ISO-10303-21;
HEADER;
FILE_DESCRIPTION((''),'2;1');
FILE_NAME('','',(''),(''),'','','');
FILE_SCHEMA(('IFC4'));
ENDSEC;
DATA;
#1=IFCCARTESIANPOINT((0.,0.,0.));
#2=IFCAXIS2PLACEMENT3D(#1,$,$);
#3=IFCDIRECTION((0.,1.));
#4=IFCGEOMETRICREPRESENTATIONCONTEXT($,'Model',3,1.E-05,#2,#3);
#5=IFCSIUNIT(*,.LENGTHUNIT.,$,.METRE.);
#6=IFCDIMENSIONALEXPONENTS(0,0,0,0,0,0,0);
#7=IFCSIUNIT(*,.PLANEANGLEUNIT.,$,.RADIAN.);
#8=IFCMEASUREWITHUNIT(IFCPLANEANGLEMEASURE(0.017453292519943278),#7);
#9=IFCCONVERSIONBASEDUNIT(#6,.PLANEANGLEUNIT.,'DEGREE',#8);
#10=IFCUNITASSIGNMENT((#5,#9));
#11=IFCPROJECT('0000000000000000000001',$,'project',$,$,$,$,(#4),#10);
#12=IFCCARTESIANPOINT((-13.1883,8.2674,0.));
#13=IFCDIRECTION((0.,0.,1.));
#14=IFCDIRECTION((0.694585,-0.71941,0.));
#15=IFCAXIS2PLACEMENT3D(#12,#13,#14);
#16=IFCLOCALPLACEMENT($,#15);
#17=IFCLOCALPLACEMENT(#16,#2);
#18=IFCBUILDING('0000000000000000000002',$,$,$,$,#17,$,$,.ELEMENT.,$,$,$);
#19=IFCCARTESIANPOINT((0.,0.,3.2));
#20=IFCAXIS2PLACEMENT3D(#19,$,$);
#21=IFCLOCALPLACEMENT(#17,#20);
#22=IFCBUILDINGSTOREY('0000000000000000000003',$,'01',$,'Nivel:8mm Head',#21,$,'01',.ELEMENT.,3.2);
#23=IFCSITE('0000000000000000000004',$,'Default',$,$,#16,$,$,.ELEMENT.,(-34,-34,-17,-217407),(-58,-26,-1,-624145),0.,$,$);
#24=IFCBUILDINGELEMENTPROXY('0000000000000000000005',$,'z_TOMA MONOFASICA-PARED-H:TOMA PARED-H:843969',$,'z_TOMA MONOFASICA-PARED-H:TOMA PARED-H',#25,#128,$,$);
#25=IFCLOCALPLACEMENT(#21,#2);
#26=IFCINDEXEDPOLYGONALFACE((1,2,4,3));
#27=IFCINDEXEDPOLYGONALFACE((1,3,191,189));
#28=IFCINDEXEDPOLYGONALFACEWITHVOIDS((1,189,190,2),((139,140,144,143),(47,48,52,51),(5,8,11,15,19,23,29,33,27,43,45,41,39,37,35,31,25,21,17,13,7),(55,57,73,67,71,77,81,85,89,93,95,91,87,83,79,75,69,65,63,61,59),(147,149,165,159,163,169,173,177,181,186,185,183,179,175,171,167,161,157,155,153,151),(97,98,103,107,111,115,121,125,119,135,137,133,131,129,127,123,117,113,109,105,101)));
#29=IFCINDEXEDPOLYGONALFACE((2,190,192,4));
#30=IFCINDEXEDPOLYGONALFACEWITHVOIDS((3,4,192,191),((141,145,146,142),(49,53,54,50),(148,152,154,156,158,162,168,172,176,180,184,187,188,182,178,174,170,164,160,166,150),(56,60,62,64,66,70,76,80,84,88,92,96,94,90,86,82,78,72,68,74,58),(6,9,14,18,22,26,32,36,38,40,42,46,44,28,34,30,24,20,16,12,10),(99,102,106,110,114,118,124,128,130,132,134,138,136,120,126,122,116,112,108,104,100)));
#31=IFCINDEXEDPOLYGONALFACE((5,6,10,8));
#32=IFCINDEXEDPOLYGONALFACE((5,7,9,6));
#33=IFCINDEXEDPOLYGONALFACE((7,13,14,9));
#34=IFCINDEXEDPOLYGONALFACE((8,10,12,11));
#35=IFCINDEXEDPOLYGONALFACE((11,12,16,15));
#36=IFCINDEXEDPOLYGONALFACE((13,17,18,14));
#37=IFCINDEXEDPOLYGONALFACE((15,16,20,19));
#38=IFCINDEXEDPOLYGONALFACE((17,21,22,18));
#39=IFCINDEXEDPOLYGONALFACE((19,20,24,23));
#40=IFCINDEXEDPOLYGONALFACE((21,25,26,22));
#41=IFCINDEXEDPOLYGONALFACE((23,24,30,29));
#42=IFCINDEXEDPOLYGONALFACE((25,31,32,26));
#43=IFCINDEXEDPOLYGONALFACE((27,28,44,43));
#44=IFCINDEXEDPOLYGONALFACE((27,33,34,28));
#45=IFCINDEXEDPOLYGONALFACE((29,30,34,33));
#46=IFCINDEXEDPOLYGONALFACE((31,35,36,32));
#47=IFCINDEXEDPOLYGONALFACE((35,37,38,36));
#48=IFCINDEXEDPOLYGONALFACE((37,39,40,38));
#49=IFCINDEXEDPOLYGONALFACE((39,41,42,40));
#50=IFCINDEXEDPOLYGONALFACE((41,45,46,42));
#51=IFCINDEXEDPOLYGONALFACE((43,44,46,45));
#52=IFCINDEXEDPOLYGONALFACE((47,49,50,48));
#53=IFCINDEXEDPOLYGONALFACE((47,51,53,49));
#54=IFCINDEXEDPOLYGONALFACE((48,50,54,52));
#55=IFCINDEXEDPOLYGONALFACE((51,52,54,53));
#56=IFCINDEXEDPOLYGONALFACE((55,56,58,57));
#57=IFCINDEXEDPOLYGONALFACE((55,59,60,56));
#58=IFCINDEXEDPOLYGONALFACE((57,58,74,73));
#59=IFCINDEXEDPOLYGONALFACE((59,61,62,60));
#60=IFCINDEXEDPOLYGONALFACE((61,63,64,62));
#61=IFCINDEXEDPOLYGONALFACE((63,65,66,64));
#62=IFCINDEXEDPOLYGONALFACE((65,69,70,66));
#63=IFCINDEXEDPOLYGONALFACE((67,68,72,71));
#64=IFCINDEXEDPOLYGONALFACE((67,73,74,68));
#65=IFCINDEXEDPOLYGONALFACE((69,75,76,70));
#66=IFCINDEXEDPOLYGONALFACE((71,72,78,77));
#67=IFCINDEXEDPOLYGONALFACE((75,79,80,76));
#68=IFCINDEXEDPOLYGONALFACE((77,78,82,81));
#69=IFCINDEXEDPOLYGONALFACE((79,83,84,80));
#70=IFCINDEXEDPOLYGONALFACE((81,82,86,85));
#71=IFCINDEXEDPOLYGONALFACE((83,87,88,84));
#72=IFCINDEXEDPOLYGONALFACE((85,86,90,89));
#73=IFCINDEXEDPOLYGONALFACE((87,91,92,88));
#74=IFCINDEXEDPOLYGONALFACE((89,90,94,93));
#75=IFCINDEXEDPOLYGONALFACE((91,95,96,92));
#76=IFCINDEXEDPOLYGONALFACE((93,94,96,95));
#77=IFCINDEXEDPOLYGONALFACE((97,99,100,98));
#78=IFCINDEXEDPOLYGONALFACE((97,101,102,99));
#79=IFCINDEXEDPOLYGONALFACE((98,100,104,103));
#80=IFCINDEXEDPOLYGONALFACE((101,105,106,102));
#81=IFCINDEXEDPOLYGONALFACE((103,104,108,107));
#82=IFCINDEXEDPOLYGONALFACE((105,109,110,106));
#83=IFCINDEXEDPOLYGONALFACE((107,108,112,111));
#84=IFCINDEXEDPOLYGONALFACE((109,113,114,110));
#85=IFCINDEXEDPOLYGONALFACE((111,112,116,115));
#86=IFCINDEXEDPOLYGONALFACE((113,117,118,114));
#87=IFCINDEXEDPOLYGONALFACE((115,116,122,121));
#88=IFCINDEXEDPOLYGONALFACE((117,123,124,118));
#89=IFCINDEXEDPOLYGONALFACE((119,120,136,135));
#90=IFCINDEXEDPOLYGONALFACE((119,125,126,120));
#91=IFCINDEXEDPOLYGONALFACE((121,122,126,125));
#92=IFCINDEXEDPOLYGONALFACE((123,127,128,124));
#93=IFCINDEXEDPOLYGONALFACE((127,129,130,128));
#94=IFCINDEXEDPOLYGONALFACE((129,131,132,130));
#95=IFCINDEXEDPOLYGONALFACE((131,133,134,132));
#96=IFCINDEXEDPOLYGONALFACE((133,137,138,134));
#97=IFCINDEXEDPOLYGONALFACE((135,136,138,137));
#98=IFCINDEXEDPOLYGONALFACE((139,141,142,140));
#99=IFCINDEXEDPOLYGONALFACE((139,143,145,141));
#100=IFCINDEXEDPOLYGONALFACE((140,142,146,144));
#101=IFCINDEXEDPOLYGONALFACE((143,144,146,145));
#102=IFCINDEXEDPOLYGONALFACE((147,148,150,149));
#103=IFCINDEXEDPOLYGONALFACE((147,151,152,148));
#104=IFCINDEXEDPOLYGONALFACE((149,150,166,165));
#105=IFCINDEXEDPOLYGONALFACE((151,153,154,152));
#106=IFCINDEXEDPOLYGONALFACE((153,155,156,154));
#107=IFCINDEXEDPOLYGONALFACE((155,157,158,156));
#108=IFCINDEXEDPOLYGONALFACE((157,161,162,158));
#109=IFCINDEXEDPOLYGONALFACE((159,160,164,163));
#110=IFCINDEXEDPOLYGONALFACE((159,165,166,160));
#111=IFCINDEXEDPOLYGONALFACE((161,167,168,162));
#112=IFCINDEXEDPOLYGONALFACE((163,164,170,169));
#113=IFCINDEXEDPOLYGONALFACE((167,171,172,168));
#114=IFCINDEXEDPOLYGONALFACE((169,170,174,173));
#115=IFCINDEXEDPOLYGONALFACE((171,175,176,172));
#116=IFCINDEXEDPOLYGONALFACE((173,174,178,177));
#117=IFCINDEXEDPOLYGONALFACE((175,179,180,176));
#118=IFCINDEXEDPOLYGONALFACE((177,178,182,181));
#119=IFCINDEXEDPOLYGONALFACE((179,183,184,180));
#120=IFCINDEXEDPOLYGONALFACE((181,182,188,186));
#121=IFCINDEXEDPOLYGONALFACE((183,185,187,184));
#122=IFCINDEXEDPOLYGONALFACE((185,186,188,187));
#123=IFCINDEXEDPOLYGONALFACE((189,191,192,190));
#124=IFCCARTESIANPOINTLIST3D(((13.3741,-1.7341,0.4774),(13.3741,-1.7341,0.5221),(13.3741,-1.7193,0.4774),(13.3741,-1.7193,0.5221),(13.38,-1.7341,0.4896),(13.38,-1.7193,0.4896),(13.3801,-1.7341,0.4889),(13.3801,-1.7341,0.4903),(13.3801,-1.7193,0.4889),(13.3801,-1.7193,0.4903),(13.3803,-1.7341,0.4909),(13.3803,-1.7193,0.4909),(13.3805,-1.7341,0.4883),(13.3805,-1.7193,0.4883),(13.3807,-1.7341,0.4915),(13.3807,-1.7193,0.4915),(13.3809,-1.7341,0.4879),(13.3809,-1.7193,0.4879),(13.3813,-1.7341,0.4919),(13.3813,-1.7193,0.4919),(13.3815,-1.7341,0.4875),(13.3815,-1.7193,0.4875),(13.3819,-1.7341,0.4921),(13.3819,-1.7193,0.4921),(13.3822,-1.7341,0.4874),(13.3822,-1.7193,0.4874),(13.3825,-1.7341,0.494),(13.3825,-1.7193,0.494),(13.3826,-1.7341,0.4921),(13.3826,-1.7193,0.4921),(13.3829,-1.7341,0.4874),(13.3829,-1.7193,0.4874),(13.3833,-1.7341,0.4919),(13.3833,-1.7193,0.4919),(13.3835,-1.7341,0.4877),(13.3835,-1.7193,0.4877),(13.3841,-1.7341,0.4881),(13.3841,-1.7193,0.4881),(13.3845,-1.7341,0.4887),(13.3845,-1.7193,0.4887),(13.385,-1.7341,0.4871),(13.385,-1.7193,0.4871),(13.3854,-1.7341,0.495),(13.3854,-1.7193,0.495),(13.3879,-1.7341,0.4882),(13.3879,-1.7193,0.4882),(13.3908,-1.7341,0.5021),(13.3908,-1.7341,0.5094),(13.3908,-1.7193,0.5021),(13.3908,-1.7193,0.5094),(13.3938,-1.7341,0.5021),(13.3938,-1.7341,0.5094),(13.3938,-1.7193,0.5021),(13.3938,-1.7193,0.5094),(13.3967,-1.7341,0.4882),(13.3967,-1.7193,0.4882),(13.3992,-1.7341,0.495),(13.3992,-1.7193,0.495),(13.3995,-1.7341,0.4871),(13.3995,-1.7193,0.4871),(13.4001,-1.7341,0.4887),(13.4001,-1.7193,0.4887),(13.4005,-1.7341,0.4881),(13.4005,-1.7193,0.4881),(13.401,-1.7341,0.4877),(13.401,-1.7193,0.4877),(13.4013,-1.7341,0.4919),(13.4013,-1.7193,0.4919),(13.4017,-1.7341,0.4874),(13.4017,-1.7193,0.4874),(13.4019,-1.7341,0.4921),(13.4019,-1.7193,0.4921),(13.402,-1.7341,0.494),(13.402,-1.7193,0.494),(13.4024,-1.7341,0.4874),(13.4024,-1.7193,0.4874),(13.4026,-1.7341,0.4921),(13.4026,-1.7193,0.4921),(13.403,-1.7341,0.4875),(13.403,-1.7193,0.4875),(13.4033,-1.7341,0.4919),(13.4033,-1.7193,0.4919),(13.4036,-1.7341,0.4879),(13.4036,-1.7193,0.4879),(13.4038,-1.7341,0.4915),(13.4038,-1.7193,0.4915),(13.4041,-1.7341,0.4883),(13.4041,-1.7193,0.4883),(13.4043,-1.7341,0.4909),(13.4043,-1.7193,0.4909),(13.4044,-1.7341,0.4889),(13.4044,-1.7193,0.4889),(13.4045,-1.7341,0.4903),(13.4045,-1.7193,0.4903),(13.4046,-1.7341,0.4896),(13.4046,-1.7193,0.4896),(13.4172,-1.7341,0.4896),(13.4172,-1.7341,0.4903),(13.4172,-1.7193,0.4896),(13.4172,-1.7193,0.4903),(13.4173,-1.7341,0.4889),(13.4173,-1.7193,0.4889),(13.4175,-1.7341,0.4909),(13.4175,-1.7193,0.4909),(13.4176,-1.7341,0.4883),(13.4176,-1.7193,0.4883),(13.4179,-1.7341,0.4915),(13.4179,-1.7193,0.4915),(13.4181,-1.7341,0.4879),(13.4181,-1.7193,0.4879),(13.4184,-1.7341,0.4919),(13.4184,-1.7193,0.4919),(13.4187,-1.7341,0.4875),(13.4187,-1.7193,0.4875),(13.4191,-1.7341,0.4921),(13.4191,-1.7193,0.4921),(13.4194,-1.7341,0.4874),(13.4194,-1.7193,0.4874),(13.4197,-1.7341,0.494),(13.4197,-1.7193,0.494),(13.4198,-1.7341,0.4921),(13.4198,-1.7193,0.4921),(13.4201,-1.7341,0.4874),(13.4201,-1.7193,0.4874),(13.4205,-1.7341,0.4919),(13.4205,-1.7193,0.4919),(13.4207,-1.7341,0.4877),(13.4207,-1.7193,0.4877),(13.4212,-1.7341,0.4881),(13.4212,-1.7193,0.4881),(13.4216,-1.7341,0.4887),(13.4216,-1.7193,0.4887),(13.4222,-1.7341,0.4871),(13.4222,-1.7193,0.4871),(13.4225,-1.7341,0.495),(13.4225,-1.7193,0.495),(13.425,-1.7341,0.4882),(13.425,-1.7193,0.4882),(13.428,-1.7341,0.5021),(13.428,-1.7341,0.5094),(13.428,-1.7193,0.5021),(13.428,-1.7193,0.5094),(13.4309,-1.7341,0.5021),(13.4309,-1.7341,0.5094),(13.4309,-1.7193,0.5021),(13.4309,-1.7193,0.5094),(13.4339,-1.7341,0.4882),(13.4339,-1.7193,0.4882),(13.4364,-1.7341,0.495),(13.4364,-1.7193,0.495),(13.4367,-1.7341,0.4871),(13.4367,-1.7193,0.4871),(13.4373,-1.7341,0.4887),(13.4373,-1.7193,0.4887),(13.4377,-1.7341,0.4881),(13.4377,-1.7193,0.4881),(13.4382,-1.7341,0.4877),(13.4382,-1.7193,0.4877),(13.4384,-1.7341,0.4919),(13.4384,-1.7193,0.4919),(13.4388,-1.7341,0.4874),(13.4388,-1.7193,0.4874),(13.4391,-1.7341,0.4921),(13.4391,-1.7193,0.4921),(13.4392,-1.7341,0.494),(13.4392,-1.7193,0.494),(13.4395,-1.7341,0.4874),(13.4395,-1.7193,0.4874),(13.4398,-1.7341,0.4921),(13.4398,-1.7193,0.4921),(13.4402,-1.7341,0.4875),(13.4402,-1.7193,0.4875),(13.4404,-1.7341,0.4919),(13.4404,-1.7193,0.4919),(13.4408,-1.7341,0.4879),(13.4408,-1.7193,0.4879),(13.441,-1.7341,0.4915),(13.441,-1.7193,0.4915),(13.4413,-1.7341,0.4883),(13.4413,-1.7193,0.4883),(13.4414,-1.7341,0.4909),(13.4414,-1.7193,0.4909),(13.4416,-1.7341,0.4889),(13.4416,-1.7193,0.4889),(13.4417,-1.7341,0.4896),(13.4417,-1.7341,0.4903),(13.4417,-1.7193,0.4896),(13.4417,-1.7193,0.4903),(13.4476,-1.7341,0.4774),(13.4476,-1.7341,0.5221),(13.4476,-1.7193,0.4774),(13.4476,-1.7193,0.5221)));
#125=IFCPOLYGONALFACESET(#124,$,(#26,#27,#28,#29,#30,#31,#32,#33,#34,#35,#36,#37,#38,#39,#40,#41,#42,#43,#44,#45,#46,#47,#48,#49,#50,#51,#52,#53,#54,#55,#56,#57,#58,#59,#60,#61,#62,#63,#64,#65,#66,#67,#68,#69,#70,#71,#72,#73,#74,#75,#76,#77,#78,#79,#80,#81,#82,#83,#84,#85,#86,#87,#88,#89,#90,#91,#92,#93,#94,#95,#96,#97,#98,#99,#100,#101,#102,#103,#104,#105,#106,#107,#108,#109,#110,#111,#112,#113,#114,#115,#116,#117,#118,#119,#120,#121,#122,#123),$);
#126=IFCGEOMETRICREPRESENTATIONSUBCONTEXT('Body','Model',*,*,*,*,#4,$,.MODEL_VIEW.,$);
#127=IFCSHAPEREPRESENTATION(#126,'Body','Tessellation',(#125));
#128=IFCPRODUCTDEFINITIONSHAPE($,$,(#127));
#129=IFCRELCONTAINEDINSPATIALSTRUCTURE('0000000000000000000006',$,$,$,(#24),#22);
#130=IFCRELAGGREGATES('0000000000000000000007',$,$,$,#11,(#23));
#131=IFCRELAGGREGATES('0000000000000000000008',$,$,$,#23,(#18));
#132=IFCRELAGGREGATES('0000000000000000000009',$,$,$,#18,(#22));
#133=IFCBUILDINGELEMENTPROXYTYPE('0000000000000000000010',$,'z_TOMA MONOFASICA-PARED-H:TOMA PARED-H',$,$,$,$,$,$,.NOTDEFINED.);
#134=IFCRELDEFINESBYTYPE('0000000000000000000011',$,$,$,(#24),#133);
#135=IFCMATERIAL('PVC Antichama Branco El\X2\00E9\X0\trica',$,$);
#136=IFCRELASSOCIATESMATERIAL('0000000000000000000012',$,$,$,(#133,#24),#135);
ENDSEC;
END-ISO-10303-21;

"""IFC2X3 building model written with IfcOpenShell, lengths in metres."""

from ifc_helpers import new_model, entity, si_unit, converted_unit, direction, frame, frame_2d, origin, place, context, subcontext, project, spatial, polyline, circle_curve, parameter, trimmed, segment, composite_curve, outline, extrude, source, transform, mapped, material, type_object, type_shapes, element, save


model = new_model("IFC2X3")

# Units and contexts
model_context = context("Model", 3, precision=1e-05, world=origin(), true_north=direction((0.0, 1.0)))
body_context = subcontext(model_context, "Body", "Model", "MODEL_VIEW")
ifc_project = project(units=[si_unit("LENGTHUNIT", "METRE"), converted_unit("PLANEANGLEUNIT", "DEGREE", entity("IfcPlaneAngleMeasure", 0.017453292519943278), si_unit("PLANEANGLEUNIT", "RADIAN"), dimensions=[0, 0, 0, 0, 0, 0, 0])], contexts=[model_context])

# Site, building, storey
site_placement = place(None, frame((-13.1883, 8.2674, 0.0), z_axis=(0.0, 0.0, 1.0), x_axis=(0.694585, -0.71941, 0.0)))
site = spatial("IfcSite", under=ifc_project, at=site_placement, Name="Default", CompositionType="ELEMENT", RefLatitude=(-34, -34, -17, -217407), RefLongitude=(-58, -26, -1, -624145), RefElevation=0.0)
building_placement = place(site_placement, origin())
building = spatial("IfcBuilding", under=site, at=building_placement, CompositionType="ELEMENT")
storey_placement = place(building_placement, frame((0.0, 0.0, 3.2)))
storey = spatial("IfcBuildingStorey", under=building, at=storey_placement, Name="01", ObjectType="Nivel:8mm Head", LongName="01", CompositionType="ELEMENT", Elevation=3.2)

# Building element proxy
ifc_material_1 = material(Name="PVC Antichama Branco Elétrica")
building_element_proxy_type_1 = type_object("IfcBuildingElementProxyType", Name="z_TOMA MONOFASICA-PARED-H:TOMA PARED-H", PredefinedType="NOTDEFINED", material=ifc_material_1)
shared_shape_1 = source(origin(), body_context, "Body", "SweptSolid", [
    extrude(outline(polyline([(-0.0368, -0.0223), (0.0368, -0.0223), (0.0368, 0.0223), (-0.0368, 0.0223), (-0.0368, -0.0223)]), holes=[composite_curve([segment(polyline([(0.0141, 0.0115), (0.0116, 0.0047)]), True, "CONTINUOUS"), segment(polyline([(0.0116, 0.0047), (0.0088, 0.0057)]), True, "CONTINUOUS"), segment(polyline([(0.0088, 0.0057), (0.0096, 0.0078)]), True, "CONTINUOUS"), segment(trimmed(circle_curve(frame_2d((0.0087, 0.0099), x_axis=(1.0, 0.0)), 0.0024), [parameter(27.118901)], [parameter(292.881099)], True, "PARAMETER"), False, "CONTINUOUS"), segment(polyline([(0.0108, 0.011), (0.0113, 0.0126)]), True, "CONTINUOUS"), segment(polyline([(0.0113, 0.0126), (0.0141, 0.0115)]), True, "CONTINUOUS")], self_intersect=False), composite_curve([segment(polyline([(0.0255, 0.0047), (0.023, 0.0115)]), True, "CONTINUOUS"), segment(polyline([(0.023, 0.0115), (0.0258, 0.0126)]), True, "CONTINUOUS"), segment(polyline([(0.0258, 0.0126), (0.0264, 0.011)]), True, "CONTINUOUS"), segment(trimmed(circle_curve(frame_2d((0.0285, 0.0099), x_axis=(1.0, 0.0)), 0.0024), [parameter(247.118901)], [parameter(152.881099)], True, "PARAMETER"), False, "CONTINUOUS"), segment(polyline([(0.0276, 0.0078), (0.0283, 0.0057)]), True, "CONTINUOUS"), segment(polyline([(0.0283, 0.0057), (0.0255, 0.0047)]), True, "CONTINUOUS")], self_intersect=False), polyline([(0.0201, -0.0024), (0.0201, -0.0097), (0.0171, -0.0097), (0.0171, -0.0024), (0.0201, -0.0024)]), composite_curve([segment(polyline([(-0.0141, 0.0115), (-0.0113, 0.0126)]), True, "CONTINUOUS"), segment(polyline([(-0.0113, 0.0126), (-0.0108, 0.011)]), True, "CONTINUOUS"), segment(trimmed(circle_curve(frame_2d((-0.0087, 0.0099), x_axis=(1.0, 0.0)), 0.0024), [parameter(247.118901)], [parameter(152.881099)], True, "PARAMETER"), False, "CONTINUOUS"), segment(polyline([(-0.0096, 0.0078), (-0.0088, 0.0057)]), True, "CONTINUOUS"), segment(polyline([(-0.0088, 0.0057), (-0.0116, 0.0047)]), True, "CONTINUOUS"), segment(polyline([(-0.0116, 0.0047), (-0.0141, 0.0115)]), True, "CONTINUOUS")], self_intersect=False), composite_curve([segment(polyline([(-0.0255, 0.0047), (-0.0283, 0.0057)]), True, "CONTINUOUS"), segment(polyline([(-0.0283, 0.0057), (-0.0276, 0.0078)]), True, "CONTINUOUS"), segment(trimmed(circle_curve(frame_2d((-0.0285, 0.0099), x_axis=(1.0, 0.0)), 0.0024), [parameter(27.118901)], [parameter(292.881099)], True, "PARAMETER"), False, "CONTINUOUS"), segment(polyline([(-0.0264, 0.011), (-0.0258, 0.0126)]), True, "CONTINUOUS"), segment(polyline([(-0.0258, 0.0126), (-0.023, 0.0115)]), True, "CONTINUOUS"), segment(polyline([(-0.023, 0.0115), (-0.0255, 0.0047)]), True, "CONTINUOUS")], self_intersect=False), polyline([(-0.0201, -0.0024), (-0.0171, -0.0024), (-0.0171, -0.0097), (-0.0201, -0.0097), (-0.0201, -0.0024)])]), frame((0.0, -0.005, 0.0223), z_axis=(0.0, 1.0, 0.0), x_axis=(1.0, 0.0, 0.0)), (0.0, 0.0, 1.0), 0.0148),
])
type_shapes(building_element_proxy_type_1, [shared_shape_1])
for number, where, z_axis, x_axis, name in (
    (1, (13.4109, -1.7243, 0.4774), (0.0, 0.0, 1.0), (-1.0, 0.0, 0.0), "z_TOMA MONOFASICA-PARED-H:TOMA PARED-H:843969"),
):
    element("IfcBuildingElementProxy", number, at=place(storey_placement, frame(where, z_axis=z_axis, x_axis=x_axis)), inside=storey, type_object=building_element_proxy_type_1, material=ifc_material_1, Name=name, ObjectType="z_TOMA MONOFASICA-PARED-H:TOMA PARED-H", context=body_context, shape_type="MappedRepresentation", body=[
        mapped(shared_shape_1, transform((0.0, 0.0, 0.0), scale=1.0)),
    ])

save(model, "model.ifc")
